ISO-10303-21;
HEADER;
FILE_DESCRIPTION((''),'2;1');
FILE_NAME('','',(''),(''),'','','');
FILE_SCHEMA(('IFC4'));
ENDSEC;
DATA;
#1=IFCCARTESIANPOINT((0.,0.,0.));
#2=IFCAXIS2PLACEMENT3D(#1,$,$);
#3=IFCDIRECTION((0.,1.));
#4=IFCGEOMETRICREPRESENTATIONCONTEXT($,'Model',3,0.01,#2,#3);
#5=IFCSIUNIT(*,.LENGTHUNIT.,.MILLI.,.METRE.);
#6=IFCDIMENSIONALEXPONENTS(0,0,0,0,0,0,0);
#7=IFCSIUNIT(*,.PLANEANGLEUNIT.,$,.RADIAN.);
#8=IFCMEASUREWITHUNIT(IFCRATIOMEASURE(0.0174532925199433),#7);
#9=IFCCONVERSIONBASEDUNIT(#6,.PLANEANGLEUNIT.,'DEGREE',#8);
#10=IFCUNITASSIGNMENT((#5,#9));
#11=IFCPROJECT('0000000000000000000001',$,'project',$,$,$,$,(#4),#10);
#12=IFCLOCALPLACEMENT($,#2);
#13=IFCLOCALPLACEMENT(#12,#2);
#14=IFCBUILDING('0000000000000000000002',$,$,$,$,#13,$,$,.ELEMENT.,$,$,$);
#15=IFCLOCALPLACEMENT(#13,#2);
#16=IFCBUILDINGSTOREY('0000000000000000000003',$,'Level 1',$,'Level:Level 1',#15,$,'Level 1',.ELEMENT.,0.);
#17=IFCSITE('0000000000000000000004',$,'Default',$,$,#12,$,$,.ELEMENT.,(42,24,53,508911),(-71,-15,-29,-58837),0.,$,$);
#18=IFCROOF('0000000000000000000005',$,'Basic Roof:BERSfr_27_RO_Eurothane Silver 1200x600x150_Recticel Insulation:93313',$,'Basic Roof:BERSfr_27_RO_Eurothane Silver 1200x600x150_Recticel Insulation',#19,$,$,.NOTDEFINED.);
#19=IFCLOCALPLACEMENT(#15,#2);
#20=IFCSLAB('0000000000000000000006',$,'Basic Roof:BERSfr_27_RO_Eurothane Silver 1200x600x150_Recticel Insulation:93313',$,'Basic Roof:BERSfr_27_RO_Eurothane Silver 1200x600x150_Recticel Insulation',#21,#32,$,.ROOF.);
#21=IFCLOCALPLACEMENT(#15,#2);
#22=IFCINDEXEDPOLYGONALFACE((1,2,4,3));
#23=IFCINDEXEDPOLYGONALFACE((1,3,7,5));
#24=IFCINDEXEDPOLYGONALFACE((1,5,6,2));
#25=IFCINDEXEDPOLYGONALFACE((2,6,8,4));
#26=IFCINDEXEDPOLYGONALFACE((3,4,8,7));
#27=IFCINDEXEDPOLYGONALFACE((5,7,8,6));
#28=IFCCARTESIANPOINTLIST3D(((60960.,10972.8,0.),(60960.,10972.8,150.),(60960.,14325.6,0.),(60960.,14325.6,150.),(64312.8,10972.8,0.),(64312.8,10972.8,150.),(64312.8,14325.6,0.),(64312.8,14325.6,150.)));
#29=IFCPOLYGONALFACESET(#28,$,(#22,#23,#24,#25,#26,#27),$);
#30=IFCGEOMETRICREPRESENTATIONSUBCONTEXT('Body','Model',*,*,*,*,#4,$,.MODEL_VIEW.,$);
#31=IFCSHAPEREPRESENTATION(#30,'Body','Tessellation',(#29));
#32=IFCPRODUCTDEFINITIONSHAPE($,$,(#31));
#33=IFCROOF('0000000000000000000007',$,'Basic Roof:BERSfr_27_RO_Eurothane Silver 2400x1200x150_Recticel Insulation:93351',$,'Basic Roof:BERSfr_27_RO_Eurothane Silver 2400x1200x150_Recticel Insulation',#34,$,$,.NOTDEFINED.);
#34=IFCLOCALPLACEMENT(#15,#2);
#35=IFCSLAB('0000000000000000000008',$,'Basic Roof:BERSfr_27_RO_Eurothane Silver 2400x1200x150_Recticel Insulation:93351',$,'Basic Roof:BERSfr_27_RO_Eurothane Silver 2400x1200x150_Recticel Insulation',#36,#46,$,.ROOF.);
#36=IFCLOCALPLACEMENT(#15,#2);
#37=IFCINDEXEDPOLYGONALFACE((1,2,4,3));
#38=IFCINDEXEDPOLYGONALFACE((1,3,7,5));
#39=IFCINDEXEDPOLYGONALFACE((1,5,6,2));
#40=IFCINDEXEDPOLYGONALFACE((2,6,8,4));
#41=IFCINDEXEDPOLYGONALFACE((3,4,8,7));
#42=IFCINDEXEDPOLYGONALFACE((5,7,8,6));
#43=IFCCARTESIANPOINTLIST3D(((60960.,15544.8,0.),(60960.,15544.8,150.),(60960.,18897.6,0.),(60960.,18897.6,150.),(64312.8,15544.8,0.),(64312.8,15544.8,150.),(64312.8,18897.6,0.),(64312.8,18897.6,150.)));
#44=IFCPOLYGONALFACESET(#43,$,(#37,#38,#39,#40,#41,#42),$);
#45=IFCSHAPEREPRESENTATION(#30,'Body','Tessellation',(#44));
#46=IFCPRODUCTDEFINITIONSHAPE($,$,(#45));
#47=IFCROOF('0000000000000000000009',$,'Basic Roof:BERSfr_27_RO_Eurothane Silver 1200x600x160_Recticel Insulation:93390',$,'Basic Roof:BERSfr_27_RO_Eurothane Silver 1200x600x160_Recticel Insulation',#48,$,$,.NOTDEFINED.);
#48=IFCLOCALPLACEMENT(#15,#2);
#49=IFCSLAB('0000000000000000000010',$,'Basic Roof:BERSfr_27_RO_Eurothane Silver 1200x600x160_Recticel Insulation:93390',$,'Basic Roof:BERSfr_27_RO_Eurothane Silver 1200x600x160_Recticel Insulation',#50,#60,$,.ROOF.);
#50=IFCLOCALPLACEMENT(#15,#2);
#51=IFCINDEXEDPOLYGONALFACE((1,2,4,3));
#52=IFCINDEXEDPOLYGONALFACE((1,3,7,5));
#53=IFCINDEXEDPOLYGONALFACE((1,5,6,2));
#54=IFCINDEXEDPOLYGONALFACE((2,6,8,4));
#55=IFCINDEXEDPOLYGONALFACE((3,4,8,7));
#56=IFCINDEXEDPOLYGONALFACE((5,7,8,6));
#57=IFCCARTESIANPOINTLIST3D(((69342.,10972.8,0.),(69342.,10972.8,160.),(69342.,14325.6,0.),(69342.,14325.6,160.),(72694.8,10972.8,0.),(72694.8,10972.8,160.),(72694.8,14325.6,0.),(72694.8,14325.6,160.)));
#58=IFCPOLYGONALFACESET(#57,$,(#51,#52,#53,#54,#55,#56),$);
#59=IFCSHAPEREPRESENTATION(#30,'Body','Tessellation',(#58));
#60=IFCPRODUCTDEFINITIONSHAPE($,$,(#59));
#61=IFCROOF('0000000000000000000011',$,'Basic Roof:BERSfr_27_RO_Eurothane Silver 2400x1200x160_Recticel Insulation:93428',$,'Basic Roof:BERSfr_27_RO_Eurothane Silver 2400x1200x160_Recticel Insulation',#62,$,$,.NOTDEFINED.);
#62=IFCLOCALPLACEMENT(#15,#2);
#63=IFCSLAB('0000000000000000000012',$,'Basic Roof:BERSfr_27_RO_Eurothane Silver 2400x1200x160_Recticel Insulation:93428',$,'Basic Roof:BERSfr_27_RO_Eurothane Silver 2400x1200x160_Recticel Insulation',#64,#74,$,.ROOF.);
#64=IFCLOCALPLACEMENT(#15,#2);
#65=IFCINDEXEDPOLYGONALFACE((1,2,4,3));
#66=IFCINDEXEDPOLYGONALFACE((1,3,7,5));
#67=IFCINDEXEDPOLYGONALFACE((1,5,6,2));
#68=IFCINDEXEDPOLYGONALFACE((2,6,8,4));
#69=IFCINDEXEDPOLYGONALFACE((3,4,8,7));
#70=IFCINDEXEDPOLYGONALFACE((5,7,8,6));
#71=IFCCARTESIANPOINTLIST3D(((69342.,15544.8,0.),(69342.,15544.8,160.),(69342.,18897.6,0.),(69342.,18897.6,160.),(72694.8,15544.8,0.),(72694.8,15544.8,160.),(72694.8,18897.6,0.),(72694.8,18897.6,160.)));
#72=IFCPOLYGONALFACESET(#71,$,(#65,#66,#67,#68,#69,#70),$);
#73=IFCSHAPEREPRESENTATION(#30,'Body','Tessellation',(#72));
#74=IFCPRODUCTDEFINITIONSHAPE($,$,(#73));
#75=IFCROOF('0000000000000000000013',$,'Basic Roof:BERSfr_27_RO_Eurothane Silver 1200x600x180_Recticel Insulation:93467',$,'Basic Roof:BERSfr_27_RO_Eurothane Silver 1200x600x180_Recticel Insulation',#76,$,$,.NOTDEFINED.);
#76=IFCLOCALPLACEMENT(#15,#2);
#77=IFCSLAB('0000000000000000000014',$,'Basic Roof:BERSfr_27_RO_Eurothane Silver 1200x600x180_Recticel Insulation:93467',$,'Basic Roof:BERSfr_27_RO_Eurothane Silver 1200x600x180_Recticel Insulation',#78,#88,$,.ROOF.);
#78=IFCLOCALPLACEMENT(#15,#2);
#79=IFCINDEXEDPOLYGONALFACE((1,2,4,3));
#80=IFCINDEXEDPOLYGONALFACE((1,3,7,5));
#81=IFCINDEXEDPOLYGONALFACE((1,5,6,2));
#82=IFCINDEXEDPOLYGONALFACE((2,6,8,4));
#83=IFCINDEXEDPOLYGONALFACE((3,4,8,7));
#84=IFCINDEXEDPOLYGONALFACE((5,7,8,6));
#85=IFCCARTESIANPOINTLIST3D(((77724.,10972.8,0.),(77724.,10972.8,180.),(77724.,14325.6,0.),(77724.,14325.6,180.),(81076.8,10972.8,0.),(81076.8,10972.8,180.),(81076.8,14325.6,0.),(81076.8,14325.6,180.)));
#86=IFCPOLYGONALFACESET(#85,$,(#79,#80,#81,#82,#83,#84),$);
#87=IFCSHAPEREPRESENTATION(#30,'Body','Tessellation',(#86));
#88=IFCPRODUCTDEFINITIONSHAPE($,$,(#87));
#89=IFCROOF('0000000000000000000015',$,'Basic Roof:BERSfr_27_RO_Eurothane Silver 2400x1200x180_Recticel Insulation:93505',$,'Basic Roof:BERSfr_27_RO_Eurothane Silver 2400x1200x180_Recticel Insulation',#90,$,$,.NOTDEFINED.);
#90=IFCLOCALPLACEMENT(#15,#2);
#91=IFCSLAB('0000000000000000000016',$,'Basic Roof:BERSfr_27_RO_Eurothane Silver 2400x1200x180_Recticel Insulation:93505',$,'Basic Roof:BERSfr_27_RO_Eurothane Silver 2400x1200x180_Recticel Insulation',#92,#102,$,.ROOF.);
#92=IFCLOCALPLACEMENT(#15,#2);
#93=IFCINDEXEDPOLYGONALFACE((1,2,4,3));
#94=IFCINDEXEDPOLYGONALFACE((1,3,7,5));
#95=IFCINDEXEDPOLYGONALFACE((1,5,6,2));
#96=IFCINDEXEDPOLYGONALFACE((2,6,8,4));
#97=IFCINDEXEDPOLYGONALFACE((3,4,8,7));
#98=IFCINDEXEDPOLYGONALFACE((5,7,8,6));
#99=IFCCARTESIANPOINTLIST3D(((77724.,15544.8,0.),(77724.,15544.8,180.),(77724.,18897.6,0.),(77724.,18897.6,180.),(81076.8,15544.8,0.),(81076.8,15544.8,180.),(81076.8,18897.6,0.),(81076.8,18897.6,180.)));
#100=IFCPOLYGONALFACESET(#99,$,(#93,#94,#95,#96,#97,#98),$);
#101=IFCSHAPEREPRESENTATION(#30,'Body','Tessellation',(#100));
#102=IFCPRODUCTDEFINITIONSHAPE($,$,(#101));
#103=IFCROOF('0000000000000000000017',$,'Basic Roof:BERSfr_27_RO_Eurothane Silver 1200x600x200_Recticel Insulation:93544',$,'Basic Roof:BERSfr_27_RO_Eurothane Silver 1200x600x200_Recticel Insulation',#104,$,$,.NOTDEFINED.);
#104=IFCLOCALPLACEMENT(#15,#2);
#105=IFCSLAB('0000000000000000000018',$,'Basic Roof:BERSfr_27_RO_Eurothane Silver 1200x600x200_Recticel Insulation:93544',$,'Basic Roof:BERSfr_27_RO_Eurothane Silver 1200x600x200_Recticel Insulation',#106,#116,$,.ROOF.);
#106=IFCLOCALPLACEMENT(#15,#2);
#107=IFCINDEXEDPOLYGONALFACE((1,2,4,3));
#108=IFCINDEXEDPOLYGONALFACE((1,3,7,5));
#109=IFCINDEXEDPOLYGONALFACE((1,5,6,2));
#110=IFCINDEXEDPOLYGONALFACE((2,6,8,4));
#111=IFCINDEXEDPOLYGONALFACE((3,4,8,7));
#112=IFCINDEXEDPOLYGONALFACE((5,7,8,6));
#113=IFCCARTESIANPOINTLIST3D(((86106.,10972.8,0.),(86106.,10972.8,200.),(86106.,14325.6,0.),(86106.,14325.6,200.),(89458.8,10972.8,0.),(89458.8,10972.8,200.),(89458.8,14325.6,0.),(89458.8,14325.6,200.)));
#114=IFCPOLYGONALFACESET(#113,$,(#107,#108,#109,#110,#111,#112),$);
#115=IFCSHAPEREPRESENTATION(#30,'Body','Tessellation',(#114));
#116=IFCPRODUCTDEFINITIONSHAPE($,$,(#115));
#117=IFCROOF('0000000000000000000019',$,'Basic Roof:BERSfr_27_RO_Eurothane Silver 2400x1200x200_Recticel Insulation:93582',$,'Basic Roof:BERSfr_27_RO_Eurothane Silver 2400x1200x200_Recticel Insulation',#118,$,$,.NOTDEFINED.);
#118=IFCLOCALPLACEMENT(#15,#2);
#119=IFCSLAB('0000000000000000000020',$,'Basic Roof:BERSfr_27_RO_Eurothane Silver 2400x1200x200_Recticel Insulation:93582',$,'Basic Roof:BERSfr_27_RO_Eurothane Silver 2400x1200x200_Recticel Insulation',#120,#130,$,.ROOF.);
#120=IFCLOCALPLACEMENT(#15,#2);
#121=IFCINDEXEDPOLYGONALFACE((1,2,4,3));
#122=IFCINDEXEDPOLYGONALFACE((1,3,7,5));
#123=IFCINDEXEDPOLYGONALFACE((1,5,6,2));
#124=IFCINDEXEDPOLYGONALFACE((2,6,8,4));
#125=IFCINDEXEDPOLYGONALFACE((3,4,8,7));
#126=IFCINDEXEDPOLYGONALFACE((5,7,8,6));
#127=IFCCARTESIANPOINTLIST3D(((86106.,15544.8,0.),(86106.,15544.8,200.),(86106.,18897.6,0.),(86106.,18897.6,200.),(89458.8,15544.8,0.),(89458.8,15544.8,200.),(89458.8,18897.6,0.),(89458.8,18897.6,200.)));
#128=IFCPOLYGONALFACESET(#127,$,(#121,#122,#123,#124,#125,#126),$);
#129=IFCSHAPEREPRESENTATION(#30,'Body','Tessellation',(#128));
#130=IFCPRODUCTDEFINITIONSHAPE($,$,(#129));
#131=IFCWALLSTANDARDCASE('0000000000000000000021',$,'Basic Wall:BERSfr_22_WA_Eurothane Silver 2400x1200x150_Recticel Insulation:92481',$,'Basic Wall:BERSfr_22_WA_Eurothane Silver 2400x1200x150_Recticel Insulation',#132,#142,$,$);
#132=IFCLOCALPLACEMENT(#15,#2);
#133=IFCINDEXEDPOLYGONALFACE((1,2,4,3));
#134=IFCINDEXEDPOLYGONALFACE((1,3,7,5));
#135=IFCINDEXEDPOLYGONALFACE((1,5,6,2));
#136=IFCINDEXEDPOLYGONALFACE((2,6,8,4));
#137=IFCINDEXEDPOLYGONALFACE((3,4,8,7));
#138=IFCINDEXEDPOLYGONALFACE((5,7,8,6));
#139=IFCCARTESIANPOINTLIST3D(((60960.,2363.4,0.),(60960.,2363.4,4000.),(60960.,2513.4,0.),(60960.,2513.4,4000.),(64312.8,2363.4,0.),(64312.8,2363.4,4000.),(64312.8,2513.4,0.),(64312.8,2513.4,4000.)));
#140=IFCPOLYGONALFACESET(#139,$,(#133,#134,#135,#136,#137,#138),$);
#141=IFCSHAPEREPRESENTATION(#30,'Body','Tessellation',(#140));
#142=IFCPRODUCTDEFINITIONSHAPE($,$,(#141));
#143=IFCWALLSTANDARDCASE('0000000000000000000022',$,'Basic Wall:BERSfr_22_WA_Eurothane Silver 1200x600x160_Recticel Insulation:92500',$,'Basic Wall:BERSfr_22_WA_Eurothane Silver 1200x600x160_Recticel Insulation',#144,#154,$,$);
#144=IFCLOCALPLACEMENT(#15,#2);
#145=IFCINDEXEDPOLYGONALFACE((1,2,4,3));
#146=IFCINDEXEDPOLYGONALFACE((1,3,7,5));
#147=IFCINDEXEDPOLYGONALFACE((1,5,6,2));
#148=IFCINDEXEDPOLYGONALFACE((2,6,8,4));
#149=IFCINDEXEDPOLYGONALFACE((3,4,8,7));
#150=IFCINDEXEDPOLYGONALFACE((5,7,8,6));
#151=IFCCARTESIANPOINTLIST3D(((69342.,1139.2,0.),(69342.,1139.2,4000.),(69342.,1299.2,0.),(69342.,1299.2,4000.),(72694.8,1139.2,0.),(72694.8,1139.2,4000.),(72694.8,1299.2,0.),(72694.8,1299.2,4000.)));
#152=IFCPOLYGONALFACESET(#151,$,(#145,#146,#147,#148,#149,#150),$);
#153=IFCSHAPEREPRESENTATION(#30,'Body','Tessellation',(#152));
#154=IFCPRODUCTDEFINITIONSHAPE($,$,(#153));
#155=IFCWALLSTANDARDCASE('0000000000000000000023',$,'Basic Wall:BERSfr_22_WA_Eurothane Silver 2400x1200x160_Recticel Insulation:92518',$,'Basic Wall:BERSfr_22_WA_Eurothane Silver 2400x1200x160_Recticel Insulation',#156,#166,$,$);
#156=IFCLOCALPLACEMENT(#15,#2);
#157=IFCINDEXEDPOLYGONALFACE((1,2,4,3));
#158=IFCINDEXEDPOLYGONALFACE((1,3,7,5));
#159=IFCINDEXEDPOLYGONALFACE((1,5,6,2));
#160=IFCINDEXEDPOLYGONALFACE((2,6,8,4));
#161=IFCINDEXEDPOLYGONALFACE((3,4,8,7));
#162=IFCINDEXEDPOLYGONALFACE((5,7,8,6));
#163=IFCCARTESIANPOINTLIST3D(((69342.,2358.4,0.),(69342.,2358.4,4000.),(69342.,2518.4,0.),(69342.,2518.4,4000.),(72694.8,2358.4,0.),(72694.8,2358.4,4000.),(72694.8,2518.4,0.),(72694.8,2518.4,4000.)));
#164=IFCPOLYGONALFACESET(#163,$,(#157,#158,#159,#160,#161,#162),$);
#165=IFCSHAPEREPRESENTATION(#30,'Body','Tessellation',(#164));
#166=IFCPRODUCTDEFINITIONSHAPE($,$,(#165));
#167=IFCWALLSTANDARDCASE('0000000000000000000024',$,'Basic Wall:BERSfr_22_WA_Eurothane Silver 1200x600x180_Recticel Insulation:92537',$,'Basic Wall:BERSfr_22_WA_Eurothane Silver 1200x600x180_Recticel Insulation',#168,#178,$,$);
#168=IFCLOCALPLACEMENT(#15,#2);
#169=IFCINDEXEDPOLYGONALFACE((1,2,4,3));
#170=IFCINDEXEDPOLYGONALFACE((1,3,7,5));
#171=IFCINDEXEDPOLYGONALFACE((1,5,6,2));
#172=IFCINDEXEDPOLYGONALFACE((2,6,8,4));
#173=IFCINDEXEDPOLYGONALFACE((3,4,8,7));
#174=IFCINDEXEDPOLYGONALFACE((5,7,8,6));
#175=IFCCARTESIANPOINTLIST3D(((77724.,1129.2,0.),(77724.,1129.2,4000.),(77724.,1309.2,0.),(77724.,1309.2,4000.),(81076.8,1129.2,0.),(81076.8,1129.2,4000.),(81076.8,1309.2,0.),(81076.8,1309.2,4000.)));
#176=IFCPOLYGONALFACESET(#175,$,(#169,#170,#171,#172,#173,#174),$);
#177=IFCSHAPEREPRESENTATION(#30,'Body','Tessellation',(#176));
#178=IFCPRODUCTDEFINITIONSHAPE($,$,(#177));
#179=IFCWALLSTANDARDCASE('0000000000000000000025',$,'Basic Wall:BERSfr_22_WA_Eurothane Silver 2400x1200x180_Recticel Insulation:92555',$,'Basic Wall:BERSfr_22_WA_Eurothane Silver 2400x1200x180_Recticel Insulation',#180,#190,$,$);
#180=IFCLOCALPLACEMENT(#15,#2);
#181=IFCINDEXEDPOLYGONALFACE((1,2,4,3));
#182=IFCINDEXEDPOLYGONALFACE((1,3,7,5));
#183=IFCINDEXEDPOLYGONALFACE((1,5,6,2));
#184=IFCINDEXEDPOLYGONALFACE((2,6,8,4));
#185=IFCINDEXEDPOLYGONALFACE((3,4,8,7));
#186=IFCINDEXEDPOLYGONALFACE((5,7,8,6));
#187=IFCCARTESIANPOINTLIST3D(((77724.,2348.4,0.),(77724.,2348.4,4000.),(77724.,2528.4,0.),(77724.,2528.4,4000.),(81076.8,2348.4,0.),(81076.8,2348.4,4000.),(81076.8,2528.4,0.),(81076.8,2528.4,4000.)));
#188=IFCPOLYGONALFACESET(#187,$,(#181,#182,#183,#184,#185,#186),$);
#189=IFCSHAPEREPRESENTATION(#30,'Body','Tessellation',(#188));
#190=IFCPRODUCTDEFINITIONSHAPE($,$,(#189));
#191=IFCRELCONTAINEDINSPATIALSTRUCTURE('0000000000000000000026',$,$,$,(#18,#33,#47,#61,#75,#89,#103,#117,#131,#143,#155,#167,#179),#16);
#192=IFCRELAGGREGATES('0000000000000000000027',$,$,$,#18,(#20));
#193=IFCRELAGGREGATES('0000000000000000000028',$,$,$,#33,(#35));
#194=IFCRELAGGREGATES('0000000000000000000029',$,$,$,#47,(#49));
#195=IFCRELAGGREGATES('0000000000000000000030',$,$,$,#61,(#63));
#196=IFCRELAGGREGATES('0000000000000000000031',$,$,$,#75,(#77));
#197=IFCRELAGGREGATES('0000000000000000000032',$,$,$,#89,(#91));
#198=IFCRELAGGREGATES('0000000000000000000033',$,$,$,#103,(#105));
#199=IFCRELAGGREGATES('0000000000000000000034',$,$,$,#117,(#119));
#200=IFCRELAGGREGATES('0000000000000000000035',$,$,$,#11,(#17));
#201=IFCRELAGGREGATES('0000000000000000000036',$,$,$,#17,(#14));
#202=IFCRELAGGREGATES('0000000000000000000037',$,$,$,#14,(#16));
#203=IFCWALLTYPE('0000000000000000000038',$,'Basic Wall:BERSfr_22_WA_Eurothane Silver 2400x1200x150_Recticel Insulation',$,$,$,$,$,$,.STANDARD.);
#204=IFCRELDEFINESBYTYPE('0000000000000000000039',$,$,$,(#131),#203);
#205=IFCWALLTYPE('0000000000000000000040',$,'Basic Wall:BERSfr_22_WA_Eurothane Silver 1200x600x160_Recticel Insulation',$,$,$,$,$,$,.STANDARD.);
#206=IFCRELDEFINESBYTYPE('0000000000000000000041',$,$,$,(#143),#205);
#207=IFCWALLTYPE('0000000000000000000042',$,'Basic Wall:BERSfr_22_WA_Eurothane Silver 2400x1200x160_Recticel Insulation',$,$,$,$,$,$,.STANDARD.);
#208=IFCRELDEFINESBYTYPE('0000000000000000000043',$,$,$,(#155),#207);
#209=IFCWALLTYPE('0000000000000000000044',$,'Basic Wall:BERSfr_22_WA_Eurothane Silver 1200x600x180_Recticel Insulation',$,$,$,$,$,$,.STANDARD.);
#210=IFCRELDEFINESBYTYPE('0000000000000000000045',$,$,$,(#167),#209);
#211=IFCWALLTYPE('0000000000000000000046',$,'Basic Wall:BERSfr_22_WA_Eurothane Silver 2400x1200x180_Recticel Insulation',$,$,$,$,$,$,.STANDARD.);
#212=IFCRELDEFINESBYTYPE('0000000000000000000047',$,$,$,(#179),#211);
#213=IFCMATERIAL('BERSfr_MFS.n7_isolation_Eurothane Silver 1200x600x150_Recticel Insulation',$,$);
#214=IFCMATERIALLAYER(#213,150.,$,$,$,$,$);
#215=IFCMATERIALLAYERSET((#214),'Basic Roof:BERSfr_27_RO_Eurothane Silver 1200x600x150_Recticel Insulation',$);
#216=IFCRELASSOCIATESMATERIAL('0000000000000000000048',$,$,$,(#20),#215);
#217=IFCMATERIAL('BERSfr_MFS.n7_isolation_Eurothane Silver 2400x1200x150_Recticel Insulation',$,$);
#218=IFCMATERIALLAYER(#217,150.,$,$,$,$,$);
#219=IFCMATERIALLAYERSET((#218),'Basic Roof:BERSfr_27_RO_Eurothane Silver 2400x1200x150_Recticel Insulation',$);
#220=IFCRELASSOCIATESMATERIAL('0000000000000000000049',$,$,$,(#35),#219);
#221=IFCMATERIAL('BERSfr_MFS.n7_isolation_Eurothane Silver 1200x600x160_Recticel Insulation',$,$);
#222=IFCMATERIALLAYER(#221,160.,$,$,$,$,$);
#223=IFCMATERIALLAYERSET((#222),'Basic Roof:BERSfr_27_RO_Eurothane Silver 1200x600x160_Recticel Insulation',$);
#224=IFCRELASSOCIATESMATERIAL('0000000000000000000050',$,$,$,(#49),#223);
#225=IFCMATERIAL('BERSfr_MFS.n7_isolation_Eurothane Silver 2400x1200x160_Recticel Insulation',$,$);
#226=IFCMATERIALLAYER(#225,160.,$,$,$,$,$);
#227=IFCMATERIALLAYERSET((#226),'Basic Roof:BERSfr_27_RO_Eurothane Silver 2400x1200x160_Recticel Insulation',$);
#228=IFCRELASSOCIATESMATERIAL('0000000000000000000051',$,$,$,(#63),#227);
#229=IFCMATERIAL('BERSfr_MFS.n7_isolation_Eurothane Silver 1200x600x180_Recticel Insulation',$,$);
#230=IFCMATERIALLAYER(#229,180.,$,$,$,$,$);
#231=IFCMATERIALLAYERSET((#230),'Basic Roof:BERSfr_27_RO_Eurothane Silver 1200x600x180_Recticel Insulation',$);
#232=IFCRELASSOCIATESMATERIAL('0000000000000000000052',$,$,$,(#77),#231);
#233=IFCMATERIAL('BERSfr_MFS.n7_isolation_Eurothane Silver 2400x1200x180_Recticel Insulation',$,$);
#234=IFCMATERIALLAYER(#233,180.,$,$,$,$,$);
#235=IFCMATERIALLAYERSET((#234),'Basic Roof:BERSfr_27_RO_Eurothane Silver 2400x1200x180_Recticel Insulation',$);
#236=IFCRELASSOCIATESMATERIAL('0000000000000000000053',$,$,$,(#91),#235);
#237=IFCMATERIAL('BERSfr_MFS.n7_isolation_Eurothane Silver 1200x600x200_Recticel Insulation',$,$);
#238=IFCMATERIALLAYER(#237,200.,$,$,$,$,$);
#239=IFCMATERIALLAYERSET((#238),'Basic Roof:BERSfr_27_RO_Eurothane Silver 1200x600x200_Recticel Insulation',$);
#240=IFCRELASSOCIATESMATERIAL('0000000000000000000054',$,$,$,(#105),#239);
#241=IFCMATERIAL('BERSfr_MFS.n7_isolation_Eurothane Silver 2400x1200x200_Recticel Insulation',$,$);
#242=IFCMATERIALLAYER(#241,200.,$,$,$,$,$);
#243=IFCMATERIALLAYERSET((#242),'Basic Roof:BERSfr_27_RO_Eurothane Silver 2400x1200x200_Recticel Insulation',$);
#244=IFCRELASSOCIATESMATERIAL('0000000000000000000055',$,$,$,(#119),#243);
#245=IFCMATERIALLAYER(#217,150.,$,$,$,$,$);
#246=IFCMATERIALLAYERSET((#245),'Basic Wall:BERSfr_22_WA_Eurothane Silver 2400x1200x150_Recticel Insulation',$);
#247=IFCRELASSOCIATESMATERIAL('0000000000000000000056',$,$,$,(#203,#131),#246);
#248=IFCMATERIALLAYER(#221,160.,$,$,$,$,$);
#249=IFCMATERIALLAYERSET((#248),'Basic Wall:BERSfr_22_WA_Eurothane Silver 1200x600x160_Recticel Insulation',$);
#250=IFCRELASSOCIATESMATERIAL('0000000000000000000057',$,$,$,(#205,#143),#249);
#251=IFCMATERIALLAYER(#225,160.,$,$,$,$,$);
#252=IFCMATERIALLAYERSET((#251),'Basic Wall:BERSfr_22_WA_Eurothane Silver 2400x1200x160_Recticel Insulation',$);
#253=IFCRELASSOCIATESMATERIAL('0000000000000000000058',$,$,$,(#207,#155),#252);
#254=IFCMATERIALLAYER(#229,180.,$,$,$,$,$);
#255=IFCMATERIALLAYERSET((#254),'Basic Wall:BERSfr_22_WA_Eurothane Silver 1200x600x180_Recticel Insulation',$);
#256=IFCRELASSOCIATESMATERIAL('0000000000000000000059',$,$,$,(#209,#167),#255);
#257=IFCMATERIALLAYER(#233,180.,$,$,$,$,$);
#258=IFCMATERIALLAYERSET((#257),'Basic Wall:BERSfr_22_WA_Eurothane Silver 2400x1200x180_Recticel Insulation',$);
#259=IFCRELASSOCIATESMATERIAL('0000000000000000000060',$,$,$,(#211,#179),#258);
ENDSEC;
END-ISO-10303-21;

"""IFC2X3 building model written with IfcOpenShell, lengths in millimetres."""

from ifc_helpers import new_model, entity, si_unit, converted_unit, direction, frame, frame_2d, origin, place, context, subcontext, project, spatial, rectangle, extrude, material, layer, layer_set, layer_usage, type_object, element, aggregate, save


model = new_model("IFC2X3")

# Units and contexts
model_context = context("Model", 3, precision=0.01, world=origin(), true_north=direction((0.0, 1.0)))
body_context = subcontext(model_context, "Body", "Model", "MODEL_VIEW")
ifc_project = project(units=[si_unit("LENGTHUNIT", "METRE", prefix="MILLI"), converted_unit("PLANEANGLEUNIT", "DEGREE", entity("IfcRatioMeasure", 0.0174532925199433), si_unit("PLANEANGLEUNIT", "RADIAN"), dimensions=[0, 0, 0, 0, 0, 0, 0])], contexts=[model_context])

# Site, building, storey
site_placement = place(None, origin())
site = spatial("IfcSite", under=ifc_project, at=site_placement, Name="Default", CompositionType="ELEMENT", RefLatitude=(42, 24, 53, 508911), RefLongitude=(-71, -15, -29, -58837), RefElevation=0.0)
building_placement = place(site_placement, origin())
building = spatial("IfcBuilding", under=site, at=building_placement, CompositionType="ELEMENT")
storey_placement = place(building_placement, origin())
storey = spatial("IfcBuildingStorey", under=building, at=storey_placement, Name="Level 1", ObjectType="Level:Level 1", LongName="Level 1", CompositionType="ELEMENT", Elevation=0.0)

# Roofs, slabs
roof_1_placement = place(storey_placement, frame((60960.0, 10972.8, 0.0)))
roof_1 = element("IfcRoof", 1, at=roof_1_placement, inside=storey, Name="Basic Roof:BERSfr_27_RO_Eurothane Silver 1200x600x150_Recticel Insulation:93313", ObjectType="Basic Roof:BERSfr_27_RO_Eurothane Silver 1200x600x150_Recticel Insulation", ShapeType="NOTDEFINED")
ifc_material_1 = material(Name="BERSfr_MFS.n7_isolation_Eurothane Silver 1200x600x150_Recticel Insulation")
ifc_layer_1 = layer(ifc_material_1, 150.0)
ifc_layer_set_1 = layer_set([ifc_layer_1], Name="Basic Roof:BERSfr_27_RO_Eurothane Silver 1200x600x150_Recticel Insulation")
slab_1_placement = place(roof_1_placement, origin())
slab_1 = element("IfcSlab", 2, at=slab_1_placement, material=ifc_layer_set_1, Name="Basic Roof:BERSfr_27_RO_Eurothane Silver 1200x600x150_Recticel Insulation:93313", ObjectType="Basic Roof:BERSfr_27_RO_Eurothane Silver 1200x600x150_Recticel Insulation", PredefinedType="ROOF", context=body_context, shape_type="SweptSolid", body=[
    extrude(rectangle(XDim=3352.8, YDim=3352.8, at=frame_2d((0.0, 0.0), x_axis=(-1.0, 0.0))), frame((1676.4, 1676.4, 0.0)), (0.0, 0.0, 1.0), 150.0),
])
aggregate(roof_1, [slab_1])
roof_2_placement = place(storey_placement, frame((60960.0, 15544.8, 0.0)))
roof_2 = element("IfcRoof", 3, at=roof_2_placement, inside=storey, Name="Basic Roof:BERSfr_27_RO_Eurothane Silver 2400x1200x150_Recticel Insulation:93351", ObjectType="Basic Roof:BERSfr_27_RO_Eurothane Silver 2400x1200x150_Recticel Insulation", ShapeType="NOTDEFINED")
ifc_material_2 = material(Name="BERSfr_MFS.n7_isolation_Eurothane Silver 2400x1200x150_Recticel Insulation")
ifc_layer_2 = layer(ifc_material_2, 150.0)
ifc_layer_set_2 = layer_set([ifc_layer_2], Name="Basic Roof:BERSfr_27_RO_Eurothane Silver 2400x1200x150_Recticel Insulation")
slab_2_placement = place(roof_2_placement, origin())
slab_2 = element("IfcSlab", 4, at=slab_2_placement, material=ifc_layer_set_2, Name="Basic Roof:BERSfr_27_RO_Eurothane Silver 2400x1200x150_Recticel Insulation:93351", ObjectType="Basic Roof:BERSfr_27_RO_Eurothane Silver 2400x1200x150_Recticel Insulation", PredefinedType="ROOF", context=body_context, shape_type="SweptSolid", body=[
    extrude(rectangle(XDim=3352.8, YDim=3352.8, at=frame_2d((0.0, 0.0), x_axis=(-1.0, 0.0))), frame((1676.4, 1676.4, 0.0)), (0.0, 0.0, 1.0), 150.0),
])
aggregate(roof_2, [slab_2])
roof_3_placement = place(storey_placement, frame((69342.0, 10972.8, 0.0)))
roof_3 = element("IfcRoof", 5, at=roof_3_placement, inside=storey, Name="Basic Roof:BERSfr_27_RO_Eurothane Silver 1200x600x160_Recticel Insulation:93390", ObjectType="Basic Roof:BERSfr_27_RO_Eurothane Silver 1200x600x160_Recticel Insulation", ShapeType="NOTDEFINED")
ifc_material_3 = material(Name="BERSfr_MFS.n7_isolation_Eurothane Silver 1200x600x160_Recticel Insulation")
ifc_layer_3 = layer(ifc_material_3, 160.0)
ifc_layer_set_3 = layer_set([ifc_layer_3], Name="Basic Roof:BERSfr_27_RO_Eurothane Silver 1200x600x160_Recticel Insulation")
slab_3_placement = place(roof_3_placement, origin())
slab_3 = element("IfcSlab", 6, at=slab_3_placement, material=ifc_layer_set_3, Name="Basic Roof:BERSfr_27_RO_Eurothane Silver 1200x600x160_Recticel Insulation:93390", ObjectType="Basic Roof:BERSfr_27_RO_Eurothane Silver 1200x600x160_Recticel Insulation", PredefinedType="ROOF", context=body_context, shape_type="SweptSolid", body=[
    extrude(rectangle(XDim=3352.8, YDim=3352.8, at=frame_2d((0.0, 0.0), x_axis=(-1.0, 0.0))), frame((1676.4, 1676.4, 0.0)), (0.0, 0.0, 1.0), 160.0),
])
aggregate(roof_3, [slab_3])
roof_4_placement = place(storey_placement, frame((69342.0, 15544.8, 0.0)))
roof_4 = element("IfcRoof", 7, at=roof_4_placement, inside=storey, Name="Basic Roof:BERSfr_27_RO_Eurothane Silver 2400x1200x160_Recticel Insulation:93428", ObjectType="Basic Roof:BERSfr_27_RO_Eurothane Silver 2400x1200x160_Recticel Insulation", ShapeType="NOTDEFINED")
ifc_material_4 = material(Name="BERSfr_MFS.n7_isolation_Eurothane Silver 2400x1200x160_Recticel Insulation")
ifc_layer_4 = layer(ifc_material_4, 160.0)
ifc_layer_set_4 = layer_set([ifc_layer_4], Name="Basic Roof:BERSfr_27_RO_Eurothane Silver 2400x1200x160_Recticel Insulation")
slab_4_placement = place(roof_4_placement, origin())
slab_4 = element("IfcSlab", 8, at=slab_4_placement, material=ifc_layer_set_4, Name="Basic Roof:BERSfr_27_RO_Eurothane Silver 2400x1200x160_Recticel Insulation:93428", ObjectType="Basic Roof:BERSfr_27_RO_Eurothane Silver 2400x1200x160_Recticel Insulation", PredefinedType="ROOF", context=body_context, shape_type="SweptSolid", body=[
    extrude(rectangle(XDim=3352.8, YDim=3352.8, at=frame_2d((0.0, 0.0), x_axis=(-1.0, 0.0))), frame((1676.4, 1676.4, 0.0)), (0.0, 0.0, 1.0), 160.0),
])
aggregate(roof_4, [slab_4])
roof_5_placement = place(storey_placement, frame((77724.0, 10972.8, 0.0)))
roof_5 = element("IfcRoof", 9, at=roof_5_placement, inside=storey, Name="Basic Roof:BERSfr_27_RO_Eurothane Silver 1200x600x180_Recticel Insulation:93467", ObjectType="Basic Roof:BERSfr_27_RO_Eurothane Silver 1200x600x180_Recticel Insulation", ShapeType="NOTDEFINED")
ifc_material_5 = material(Name="BERSfr_MFS.n7_isolation_Eurothane Silver 1200x600x180_Recticel Insulation")
ifc_layer_5 = layer(ifc_material_5, 180.0)
ifc_layer_set_5 = layer_set([ifc_layer_5], Name="Basic Roof:BERSfr_27_RO_Eurothane Silver 1200x600x180_Recticel Insulation")
slab_5_placement = place(roof_5_placement, origin())
slab_5 = element("IfcSlab", 10, at=slab_5_placement, material=ifc_layer_set_5, Name="Basic Roof:BERSfr_27_RO_Eurothane Silver 1200x600x180_Recticel Insulation:93467", ObjectType="Basic Roof:BERSfr_27_RO_Eurothane Silver 1200x600x180_Recticel Insulation", PredefinedType="ROOF", context=body_context, shape_type="SweptSolid", body=[
    extrude(rectangle(XDim=3352.8, YDim=3352.8, at=frame_2d((0.0, 0.0), x_axis=(-1.0, 0.0))), frame((1676.4, 1676.4, 0.0)), (0.0, 0.0, 1.0), 180.0),
])
aggregate(roof_5, [slab_5])
roof_6_placement = place(storey_placement, frame((77724.0, 15544.8, 0.0)))
roof_6 = element("IfcRoof", 11, at=roof_6_placement, inside=storey, Name="Basic Roof:BERSfr_27_RO_Eurothane Silver 2400x1200x180_Recticel Insulation:93505", ObjectType="Basic Roof:BERSfr_27_RO_Eurothane Silver 2400x1200x180_Recticel Insulation", ShapeType="NOTDEFINED")
ifc_material_6 = material(Name="BERSfr_MFS.n7_isolation_Eurothane Silver 2400x1200x180_Recticel Insulation")
ifc_layer_6 = layer(ifc_material_6, 180.0)
ifc_layer_set_6 = layer_set([ifc_layer_6], Name="Basic Roof:BERSfr_27_RO_Eurothane Silver 2400x1200x180_Recticel Insulation")
slab_6_placement = place(roof_6_placement, origin())
slab_6 = element("IfcSlab", 12, at=slab_6_placement, material=ifc_layer_set_6, Name="Basic Roof:BERSfr_27_RO_Eurothane Silver 2400x1200x180_Recticel Insulation:93505", ObjectType="Basic Roof:BERSfr_27_RO_Eurothane Silver 2400x1200x180_Recticel Insulation", PredefinedType="ROOF", context=body_context, shape_type="SweptSolid", body=[
    extrude(rectangle(XDim=3352.8, YDim=3352.8, at=frame_2d((0.0, 0.0), x_axis=(-1.0, 0.0))), frame((1676.4, 1676.4, 0.0)), (0.0, 0.0, 1.0), 180.0),
])
aggregate(roof_6, [slab_6])
roof_7_placement = place(storey_placement, frame((86106.0, 10972.8, 0.0)))
roof_7 = element("IfcRoof", 13, at=roof_7_placement, inside=storey, Name="Basic Roof:BERSfr_27_RO_Eurothane Silver 1200x600x200_Recticel Insulation:93544", ObjectType="Basic Roof:BERSfr_27_RO_Eurothane Silver 1200x600x200_Recticel Insulation", ShapeType="NOTDEFINED")
ifc_material_7 = material(Name="BERSfr_MFS.n7_isolation_Eurothane Silver 1200x600x200_Recticel Insulation")
ifc_layer_7 = layer(ifc_material_7, 200.0)
ifc_layer_set_7 = layer_set([ifc_layer_7], Name="Basic Roof:BERSfr_27_RO_Eurothane Silver 1200x600x200_Recticel Insulation")
slab_7_placement = place(roof_7_placement, origin())
slab_7 = element("IfcSlab", 14, at=slab_7_placement, material=ifc_layer_set_7, Name="Basic Roof:BERSfr_27_RO_Eurothane Silver 1200x600x200_Recticel Insulation:93544", ObjectType="Basic Roof:BERSfr_27_RO_Eurothane Silver 1200x600x200_Recticel Insulation", PredefinedType="ROOF", context=body_context, shape_type="SweptSolid", body=[
    extrude(rectangle(XDim=3352.8, YDim=3352.8, at=frame_2d((0.0, 0.0), x_axis=(-1.0, 0.0))), frame((1676.4, 1676.4, 0.0)), (0.0, 0.0, 1.0), 200.0),
])
aggregate(roof_7, [slab_7])
roof_8_placement = place(storey_placement, frame((86106.0, 15544.8, 0.0)))
roof_8 = element("IfcRoof", 15, at=roof_8_placement, inside=storey, Name="Basic Roof:BERSfr_27_RO_Eurothane Silver 2400x1200x200_Recticel Insulation:93582", ObjectType="Basic Roof:BERSfr_27_RO_Eurothane Silver 2400x1200x200_Recticel Insulation", ShapeType="NOTDEFINED")
ifc_material_8 = material(Name="BERSfr_MFS.n7_isolation_Eurothane Silver 2400x1200x200_Recticel Insulation")
ifc_layer_8 = layer(ifc_material_8, 200.0)
ifc_layer_set_8 = layer_set([ifc_layer_8], Name="Basic Roof:BERSfr_27_RO_Eurothane Silver 2400x1200x200_Recticel Insulation")
slab_8_placement = place(roof_8_placement, origin())
slab_8 = element("IfcSlab", 16, at=slab_8_placement, material=ifc_layer_set_8, Name="Basic Roof:BERSfr_27_RO_Eurothane Silver 2400x1200x200_Recticel Insulation:93582", ObjectType="Basic Roof:BERSfr_27_RO_Eurothane Silver 2400x1200x200_Recticel Insulation", PredefinedType="ROOF", context=body_context, shape_type="SweptSolid", body=[
    extrude(rectangle(XDim=3352.8, YDim=3352.8, at=frame_2d((0.0, 0.0), x_axis=(-1.0, 0.0))), frame((1676.4, 1676.4, 0.0)), (0.0, 0.0, 1.0), 200.0),
])
aggregate(roof_8, [slab_8])

# Walls
ifc_layer_9 = layer(ifc_material_2, 150.0)
ifc_layer_set_9 = layer_set([ifc_layer_9], Name="Basic Wall:BERSfr_22_WA_Eurothane Silver 2400x1200x150_Recticel Insulation")
ifc_layer_usage_1 = layer_usage(ifc_layer_set_9, "AXIS2", "NEGATIVE", 75.0)
wall_type_1 = type_object("IfcWallType", Name="Basic Wall:BERSfr_22_WA_Eurothane Silver 2400x1200x150_Recticel Insulation", PredefinedType="STANDARD", material=ifc_layer_set_9)
wall_1_placement = place(storey_placement, frame((60960.0, 2438.4, 0.0)))
element("IfcWallStandardCase", 17, at=wall_1_placement, inside=storey, type_object=wall_type_1, material=ifc_layer_usage_1, Name="Basic Wall:BERSfr_22_WA_Eurothane Silver 2400x1200x150_Recticel Insulation:92481", ObjectType="Basic Wall:BERSfr_22_WA_Eurothane Silver 2400x1200x150_Recticel Insulation", context=body_context, shape_type="SweptSolid", body=[
    extrude(rectangle(XDim=3352.8, YDim=150.0, at=frame_2d((1676.4, 0.0), x_axis=(-1.0, 0.0))), origin(), (0.0, 0.0, 1.0), 4000.0),
])
ifc_layer_10 = layer(ifc_material_3, 160.0)
ifc_layer_set_10 = layer_set([ifc_layer_10], Name="Basic Wall:BERSfr_22_WA_Eurothane Silver 1200x600x160_Recticel Insulation")
ifc_layer_usage_2 = layer_usage(ifc_layer_set_10, "AXIS2", "NEGATIVE", 80.0)
wall_type_2 = type_object("IfcWallType", Name="Basic Wall:BERSfr_22_WA_Eurothane Silver 1200x600x160_Recticel Insulation", PredefinedType="STANDARD", material=ifc_layer_set_10)
wall_2_placement = place(storey_placement, frame((69342.0, 1219.2, 0.0)))
element("IfcWallStandardCase", 18, at=wall_2_placement, inside=storey, type_object=wall_type_2, material=ifc_layer_usage_2, Name="Basic Wall:BERSfr_22_WA_Eurothane Silver 1200x600x160_Recticel Insulation:92500", ObjectType="Basic Wall:BERSfr_22_WA_Eurothane Silver 1200x600x160_Recticel Insulation", context=body_context, shape_type="SweptSolid", body=[
    extrude(rectangle(XDim=3352.8, YDim=160.0, at=frame_2d((1676.4, 0.0), x_axis=(-1.0, 0.0))), origin(), (0.0, 0.0, 1.0), 4000.0),
])
ifc_layer_11 = layer(ifc_material_4, 160.0)
ifc_layer_set_11 = layer_set([ifc_layer_11], Name="Basic Wall:BERSfr_22_WA_Eurothane Silver 2400x1200x160_Recticel Insulation")
ifc_layer_usage_3 = layer_usage(ifc_layer_set_11, "AXIS2", "NEGATIVE", 80.0)
wall_type_3 = type_object("IfcWallType", Name="Basic Wall:BERSfr_22_WA_Eurothane Silver 2400x1200x160_Recticel Insulation", PredefinedType="STANDARD", material=ifc_layer_set_11)
wall_3_placement = place(storey_placement, frame((69342.0, 2438.4, 0.0)))
element("IfcWallStandardCase", 19, at=wall_3_placement, inside=storey, type_object=wall_type_3, material=ifc_layer_usage_3, Name="Basic Wall:BERSfr_22_WA_Eurothane Silver 2400x1200x160_Recticel Insulation:92518", ObjectType="Basic Wall:BERSfr_22_WA_Eurothane Silver 2400x1200x160_Recticel Insulation", context=body_context, shape_type="SweptSolid", body=[
    extrude(rectangle(XDim=3352.8, YDim=160.0, at=frame_2d((1676.4, 0.0), x_axis=(-1.0, 0.0))), origin(), (0.0, 0.0, 1.0), 4000.0),
])
ifc_layer_12 = layer(ifc_material_5, 180.0)
ifc_layer_set_12 = layer_set([ifc_layer_12], Name="Basic Wall:BERSfr_22_WA_Eurothane Silver 1200x600x180_Recticel Insulation")
ifc_layer_usage_4 = layer_usage(ifc_layer_set_12, "AXIS2", "NEGATIVE", 90.0)
wall_type_4 = type_object("IfcWallType", Name="Basic Wall:BERSfr_22_WA_Eurothane Silver 1200x600x180_Recticel Insulation", PredefinedType="STANDARD", material=ifc_layer_set_12)
wall_4_placement = place(storey_placement, frame((77724.0, 1219.2, 0.0)))
element("IfcWallStandardCase", 20, at=wall_4_placement, inside=storey, type_object=wall_type_4, material=ifc_layer_usage_4, Name="Basic Wall:BERSfr_22_WA_Eurothane Silver 1200x600x180_Recticel Insulation:92537", ObjectType="Basic Wall:BERSfr_22_WA_Eurothane Silver 1200x600x180_Recticel Insulation", context=body_context, shape_type="SweptSolid", body=[
    extrude(rectangle(XDim=3352.8, YDim=180.0, at=frame_2d((1676.4, 0.0), x_axis=(-1.0, 0.0))), origin(), (0.0, 0.0, 1.0), 4000.0),
])
ifc_layer_13 = layer(ifc_material_6, 180.0)
ifc_layer_set_13 = layer_set([ifc_layer_13], Name="Basic Wall:BERSfr_22_WA_Eurothane Silver 2400x1200x180_Recticel Insulation")
ifc_layer_usage_5 = layer_usage(ifc_layer_set_13, "AXIS2", "NEGATIVE", 90.0)
wall_type_5 = type_object("IfcWallType", Name="Basic Wall:BERSfr_22_WA_Eurothane Silver 2400x1200x180_Recticel Insulation", PredefinedType="STANDARD", material=ifc_layer_set_13)
wall_5_placement = place(storey_placement, frame((77724.0, 2438.4, 0.0)))
element("IfcWallStandardCase", 21, at=wall_5_placement, inside=storey, type_object=wall_type_5, material=ifc_layer_usage_5, Name="Basic Wall:BERSfr_22_WA_Eurothane Silver 2400x1200x180_Recticel Insulation:92555", ObjectType="Basic Wall:BERSfr_22_WA_Eurothane Silver 2400x1200x180_Recticel Insulation", context=body_context, shape_type="SweptSolid", body=[
    extrude(rectangle(XDim=3352.8, YDim=180.0, at=frame_2d((1676.4, 0.0), x_axis=(-1.0, 0.0))), origin(), (0.0, 0.0, 1.0), 4000.0),
])

save(model, "model.ifc")
